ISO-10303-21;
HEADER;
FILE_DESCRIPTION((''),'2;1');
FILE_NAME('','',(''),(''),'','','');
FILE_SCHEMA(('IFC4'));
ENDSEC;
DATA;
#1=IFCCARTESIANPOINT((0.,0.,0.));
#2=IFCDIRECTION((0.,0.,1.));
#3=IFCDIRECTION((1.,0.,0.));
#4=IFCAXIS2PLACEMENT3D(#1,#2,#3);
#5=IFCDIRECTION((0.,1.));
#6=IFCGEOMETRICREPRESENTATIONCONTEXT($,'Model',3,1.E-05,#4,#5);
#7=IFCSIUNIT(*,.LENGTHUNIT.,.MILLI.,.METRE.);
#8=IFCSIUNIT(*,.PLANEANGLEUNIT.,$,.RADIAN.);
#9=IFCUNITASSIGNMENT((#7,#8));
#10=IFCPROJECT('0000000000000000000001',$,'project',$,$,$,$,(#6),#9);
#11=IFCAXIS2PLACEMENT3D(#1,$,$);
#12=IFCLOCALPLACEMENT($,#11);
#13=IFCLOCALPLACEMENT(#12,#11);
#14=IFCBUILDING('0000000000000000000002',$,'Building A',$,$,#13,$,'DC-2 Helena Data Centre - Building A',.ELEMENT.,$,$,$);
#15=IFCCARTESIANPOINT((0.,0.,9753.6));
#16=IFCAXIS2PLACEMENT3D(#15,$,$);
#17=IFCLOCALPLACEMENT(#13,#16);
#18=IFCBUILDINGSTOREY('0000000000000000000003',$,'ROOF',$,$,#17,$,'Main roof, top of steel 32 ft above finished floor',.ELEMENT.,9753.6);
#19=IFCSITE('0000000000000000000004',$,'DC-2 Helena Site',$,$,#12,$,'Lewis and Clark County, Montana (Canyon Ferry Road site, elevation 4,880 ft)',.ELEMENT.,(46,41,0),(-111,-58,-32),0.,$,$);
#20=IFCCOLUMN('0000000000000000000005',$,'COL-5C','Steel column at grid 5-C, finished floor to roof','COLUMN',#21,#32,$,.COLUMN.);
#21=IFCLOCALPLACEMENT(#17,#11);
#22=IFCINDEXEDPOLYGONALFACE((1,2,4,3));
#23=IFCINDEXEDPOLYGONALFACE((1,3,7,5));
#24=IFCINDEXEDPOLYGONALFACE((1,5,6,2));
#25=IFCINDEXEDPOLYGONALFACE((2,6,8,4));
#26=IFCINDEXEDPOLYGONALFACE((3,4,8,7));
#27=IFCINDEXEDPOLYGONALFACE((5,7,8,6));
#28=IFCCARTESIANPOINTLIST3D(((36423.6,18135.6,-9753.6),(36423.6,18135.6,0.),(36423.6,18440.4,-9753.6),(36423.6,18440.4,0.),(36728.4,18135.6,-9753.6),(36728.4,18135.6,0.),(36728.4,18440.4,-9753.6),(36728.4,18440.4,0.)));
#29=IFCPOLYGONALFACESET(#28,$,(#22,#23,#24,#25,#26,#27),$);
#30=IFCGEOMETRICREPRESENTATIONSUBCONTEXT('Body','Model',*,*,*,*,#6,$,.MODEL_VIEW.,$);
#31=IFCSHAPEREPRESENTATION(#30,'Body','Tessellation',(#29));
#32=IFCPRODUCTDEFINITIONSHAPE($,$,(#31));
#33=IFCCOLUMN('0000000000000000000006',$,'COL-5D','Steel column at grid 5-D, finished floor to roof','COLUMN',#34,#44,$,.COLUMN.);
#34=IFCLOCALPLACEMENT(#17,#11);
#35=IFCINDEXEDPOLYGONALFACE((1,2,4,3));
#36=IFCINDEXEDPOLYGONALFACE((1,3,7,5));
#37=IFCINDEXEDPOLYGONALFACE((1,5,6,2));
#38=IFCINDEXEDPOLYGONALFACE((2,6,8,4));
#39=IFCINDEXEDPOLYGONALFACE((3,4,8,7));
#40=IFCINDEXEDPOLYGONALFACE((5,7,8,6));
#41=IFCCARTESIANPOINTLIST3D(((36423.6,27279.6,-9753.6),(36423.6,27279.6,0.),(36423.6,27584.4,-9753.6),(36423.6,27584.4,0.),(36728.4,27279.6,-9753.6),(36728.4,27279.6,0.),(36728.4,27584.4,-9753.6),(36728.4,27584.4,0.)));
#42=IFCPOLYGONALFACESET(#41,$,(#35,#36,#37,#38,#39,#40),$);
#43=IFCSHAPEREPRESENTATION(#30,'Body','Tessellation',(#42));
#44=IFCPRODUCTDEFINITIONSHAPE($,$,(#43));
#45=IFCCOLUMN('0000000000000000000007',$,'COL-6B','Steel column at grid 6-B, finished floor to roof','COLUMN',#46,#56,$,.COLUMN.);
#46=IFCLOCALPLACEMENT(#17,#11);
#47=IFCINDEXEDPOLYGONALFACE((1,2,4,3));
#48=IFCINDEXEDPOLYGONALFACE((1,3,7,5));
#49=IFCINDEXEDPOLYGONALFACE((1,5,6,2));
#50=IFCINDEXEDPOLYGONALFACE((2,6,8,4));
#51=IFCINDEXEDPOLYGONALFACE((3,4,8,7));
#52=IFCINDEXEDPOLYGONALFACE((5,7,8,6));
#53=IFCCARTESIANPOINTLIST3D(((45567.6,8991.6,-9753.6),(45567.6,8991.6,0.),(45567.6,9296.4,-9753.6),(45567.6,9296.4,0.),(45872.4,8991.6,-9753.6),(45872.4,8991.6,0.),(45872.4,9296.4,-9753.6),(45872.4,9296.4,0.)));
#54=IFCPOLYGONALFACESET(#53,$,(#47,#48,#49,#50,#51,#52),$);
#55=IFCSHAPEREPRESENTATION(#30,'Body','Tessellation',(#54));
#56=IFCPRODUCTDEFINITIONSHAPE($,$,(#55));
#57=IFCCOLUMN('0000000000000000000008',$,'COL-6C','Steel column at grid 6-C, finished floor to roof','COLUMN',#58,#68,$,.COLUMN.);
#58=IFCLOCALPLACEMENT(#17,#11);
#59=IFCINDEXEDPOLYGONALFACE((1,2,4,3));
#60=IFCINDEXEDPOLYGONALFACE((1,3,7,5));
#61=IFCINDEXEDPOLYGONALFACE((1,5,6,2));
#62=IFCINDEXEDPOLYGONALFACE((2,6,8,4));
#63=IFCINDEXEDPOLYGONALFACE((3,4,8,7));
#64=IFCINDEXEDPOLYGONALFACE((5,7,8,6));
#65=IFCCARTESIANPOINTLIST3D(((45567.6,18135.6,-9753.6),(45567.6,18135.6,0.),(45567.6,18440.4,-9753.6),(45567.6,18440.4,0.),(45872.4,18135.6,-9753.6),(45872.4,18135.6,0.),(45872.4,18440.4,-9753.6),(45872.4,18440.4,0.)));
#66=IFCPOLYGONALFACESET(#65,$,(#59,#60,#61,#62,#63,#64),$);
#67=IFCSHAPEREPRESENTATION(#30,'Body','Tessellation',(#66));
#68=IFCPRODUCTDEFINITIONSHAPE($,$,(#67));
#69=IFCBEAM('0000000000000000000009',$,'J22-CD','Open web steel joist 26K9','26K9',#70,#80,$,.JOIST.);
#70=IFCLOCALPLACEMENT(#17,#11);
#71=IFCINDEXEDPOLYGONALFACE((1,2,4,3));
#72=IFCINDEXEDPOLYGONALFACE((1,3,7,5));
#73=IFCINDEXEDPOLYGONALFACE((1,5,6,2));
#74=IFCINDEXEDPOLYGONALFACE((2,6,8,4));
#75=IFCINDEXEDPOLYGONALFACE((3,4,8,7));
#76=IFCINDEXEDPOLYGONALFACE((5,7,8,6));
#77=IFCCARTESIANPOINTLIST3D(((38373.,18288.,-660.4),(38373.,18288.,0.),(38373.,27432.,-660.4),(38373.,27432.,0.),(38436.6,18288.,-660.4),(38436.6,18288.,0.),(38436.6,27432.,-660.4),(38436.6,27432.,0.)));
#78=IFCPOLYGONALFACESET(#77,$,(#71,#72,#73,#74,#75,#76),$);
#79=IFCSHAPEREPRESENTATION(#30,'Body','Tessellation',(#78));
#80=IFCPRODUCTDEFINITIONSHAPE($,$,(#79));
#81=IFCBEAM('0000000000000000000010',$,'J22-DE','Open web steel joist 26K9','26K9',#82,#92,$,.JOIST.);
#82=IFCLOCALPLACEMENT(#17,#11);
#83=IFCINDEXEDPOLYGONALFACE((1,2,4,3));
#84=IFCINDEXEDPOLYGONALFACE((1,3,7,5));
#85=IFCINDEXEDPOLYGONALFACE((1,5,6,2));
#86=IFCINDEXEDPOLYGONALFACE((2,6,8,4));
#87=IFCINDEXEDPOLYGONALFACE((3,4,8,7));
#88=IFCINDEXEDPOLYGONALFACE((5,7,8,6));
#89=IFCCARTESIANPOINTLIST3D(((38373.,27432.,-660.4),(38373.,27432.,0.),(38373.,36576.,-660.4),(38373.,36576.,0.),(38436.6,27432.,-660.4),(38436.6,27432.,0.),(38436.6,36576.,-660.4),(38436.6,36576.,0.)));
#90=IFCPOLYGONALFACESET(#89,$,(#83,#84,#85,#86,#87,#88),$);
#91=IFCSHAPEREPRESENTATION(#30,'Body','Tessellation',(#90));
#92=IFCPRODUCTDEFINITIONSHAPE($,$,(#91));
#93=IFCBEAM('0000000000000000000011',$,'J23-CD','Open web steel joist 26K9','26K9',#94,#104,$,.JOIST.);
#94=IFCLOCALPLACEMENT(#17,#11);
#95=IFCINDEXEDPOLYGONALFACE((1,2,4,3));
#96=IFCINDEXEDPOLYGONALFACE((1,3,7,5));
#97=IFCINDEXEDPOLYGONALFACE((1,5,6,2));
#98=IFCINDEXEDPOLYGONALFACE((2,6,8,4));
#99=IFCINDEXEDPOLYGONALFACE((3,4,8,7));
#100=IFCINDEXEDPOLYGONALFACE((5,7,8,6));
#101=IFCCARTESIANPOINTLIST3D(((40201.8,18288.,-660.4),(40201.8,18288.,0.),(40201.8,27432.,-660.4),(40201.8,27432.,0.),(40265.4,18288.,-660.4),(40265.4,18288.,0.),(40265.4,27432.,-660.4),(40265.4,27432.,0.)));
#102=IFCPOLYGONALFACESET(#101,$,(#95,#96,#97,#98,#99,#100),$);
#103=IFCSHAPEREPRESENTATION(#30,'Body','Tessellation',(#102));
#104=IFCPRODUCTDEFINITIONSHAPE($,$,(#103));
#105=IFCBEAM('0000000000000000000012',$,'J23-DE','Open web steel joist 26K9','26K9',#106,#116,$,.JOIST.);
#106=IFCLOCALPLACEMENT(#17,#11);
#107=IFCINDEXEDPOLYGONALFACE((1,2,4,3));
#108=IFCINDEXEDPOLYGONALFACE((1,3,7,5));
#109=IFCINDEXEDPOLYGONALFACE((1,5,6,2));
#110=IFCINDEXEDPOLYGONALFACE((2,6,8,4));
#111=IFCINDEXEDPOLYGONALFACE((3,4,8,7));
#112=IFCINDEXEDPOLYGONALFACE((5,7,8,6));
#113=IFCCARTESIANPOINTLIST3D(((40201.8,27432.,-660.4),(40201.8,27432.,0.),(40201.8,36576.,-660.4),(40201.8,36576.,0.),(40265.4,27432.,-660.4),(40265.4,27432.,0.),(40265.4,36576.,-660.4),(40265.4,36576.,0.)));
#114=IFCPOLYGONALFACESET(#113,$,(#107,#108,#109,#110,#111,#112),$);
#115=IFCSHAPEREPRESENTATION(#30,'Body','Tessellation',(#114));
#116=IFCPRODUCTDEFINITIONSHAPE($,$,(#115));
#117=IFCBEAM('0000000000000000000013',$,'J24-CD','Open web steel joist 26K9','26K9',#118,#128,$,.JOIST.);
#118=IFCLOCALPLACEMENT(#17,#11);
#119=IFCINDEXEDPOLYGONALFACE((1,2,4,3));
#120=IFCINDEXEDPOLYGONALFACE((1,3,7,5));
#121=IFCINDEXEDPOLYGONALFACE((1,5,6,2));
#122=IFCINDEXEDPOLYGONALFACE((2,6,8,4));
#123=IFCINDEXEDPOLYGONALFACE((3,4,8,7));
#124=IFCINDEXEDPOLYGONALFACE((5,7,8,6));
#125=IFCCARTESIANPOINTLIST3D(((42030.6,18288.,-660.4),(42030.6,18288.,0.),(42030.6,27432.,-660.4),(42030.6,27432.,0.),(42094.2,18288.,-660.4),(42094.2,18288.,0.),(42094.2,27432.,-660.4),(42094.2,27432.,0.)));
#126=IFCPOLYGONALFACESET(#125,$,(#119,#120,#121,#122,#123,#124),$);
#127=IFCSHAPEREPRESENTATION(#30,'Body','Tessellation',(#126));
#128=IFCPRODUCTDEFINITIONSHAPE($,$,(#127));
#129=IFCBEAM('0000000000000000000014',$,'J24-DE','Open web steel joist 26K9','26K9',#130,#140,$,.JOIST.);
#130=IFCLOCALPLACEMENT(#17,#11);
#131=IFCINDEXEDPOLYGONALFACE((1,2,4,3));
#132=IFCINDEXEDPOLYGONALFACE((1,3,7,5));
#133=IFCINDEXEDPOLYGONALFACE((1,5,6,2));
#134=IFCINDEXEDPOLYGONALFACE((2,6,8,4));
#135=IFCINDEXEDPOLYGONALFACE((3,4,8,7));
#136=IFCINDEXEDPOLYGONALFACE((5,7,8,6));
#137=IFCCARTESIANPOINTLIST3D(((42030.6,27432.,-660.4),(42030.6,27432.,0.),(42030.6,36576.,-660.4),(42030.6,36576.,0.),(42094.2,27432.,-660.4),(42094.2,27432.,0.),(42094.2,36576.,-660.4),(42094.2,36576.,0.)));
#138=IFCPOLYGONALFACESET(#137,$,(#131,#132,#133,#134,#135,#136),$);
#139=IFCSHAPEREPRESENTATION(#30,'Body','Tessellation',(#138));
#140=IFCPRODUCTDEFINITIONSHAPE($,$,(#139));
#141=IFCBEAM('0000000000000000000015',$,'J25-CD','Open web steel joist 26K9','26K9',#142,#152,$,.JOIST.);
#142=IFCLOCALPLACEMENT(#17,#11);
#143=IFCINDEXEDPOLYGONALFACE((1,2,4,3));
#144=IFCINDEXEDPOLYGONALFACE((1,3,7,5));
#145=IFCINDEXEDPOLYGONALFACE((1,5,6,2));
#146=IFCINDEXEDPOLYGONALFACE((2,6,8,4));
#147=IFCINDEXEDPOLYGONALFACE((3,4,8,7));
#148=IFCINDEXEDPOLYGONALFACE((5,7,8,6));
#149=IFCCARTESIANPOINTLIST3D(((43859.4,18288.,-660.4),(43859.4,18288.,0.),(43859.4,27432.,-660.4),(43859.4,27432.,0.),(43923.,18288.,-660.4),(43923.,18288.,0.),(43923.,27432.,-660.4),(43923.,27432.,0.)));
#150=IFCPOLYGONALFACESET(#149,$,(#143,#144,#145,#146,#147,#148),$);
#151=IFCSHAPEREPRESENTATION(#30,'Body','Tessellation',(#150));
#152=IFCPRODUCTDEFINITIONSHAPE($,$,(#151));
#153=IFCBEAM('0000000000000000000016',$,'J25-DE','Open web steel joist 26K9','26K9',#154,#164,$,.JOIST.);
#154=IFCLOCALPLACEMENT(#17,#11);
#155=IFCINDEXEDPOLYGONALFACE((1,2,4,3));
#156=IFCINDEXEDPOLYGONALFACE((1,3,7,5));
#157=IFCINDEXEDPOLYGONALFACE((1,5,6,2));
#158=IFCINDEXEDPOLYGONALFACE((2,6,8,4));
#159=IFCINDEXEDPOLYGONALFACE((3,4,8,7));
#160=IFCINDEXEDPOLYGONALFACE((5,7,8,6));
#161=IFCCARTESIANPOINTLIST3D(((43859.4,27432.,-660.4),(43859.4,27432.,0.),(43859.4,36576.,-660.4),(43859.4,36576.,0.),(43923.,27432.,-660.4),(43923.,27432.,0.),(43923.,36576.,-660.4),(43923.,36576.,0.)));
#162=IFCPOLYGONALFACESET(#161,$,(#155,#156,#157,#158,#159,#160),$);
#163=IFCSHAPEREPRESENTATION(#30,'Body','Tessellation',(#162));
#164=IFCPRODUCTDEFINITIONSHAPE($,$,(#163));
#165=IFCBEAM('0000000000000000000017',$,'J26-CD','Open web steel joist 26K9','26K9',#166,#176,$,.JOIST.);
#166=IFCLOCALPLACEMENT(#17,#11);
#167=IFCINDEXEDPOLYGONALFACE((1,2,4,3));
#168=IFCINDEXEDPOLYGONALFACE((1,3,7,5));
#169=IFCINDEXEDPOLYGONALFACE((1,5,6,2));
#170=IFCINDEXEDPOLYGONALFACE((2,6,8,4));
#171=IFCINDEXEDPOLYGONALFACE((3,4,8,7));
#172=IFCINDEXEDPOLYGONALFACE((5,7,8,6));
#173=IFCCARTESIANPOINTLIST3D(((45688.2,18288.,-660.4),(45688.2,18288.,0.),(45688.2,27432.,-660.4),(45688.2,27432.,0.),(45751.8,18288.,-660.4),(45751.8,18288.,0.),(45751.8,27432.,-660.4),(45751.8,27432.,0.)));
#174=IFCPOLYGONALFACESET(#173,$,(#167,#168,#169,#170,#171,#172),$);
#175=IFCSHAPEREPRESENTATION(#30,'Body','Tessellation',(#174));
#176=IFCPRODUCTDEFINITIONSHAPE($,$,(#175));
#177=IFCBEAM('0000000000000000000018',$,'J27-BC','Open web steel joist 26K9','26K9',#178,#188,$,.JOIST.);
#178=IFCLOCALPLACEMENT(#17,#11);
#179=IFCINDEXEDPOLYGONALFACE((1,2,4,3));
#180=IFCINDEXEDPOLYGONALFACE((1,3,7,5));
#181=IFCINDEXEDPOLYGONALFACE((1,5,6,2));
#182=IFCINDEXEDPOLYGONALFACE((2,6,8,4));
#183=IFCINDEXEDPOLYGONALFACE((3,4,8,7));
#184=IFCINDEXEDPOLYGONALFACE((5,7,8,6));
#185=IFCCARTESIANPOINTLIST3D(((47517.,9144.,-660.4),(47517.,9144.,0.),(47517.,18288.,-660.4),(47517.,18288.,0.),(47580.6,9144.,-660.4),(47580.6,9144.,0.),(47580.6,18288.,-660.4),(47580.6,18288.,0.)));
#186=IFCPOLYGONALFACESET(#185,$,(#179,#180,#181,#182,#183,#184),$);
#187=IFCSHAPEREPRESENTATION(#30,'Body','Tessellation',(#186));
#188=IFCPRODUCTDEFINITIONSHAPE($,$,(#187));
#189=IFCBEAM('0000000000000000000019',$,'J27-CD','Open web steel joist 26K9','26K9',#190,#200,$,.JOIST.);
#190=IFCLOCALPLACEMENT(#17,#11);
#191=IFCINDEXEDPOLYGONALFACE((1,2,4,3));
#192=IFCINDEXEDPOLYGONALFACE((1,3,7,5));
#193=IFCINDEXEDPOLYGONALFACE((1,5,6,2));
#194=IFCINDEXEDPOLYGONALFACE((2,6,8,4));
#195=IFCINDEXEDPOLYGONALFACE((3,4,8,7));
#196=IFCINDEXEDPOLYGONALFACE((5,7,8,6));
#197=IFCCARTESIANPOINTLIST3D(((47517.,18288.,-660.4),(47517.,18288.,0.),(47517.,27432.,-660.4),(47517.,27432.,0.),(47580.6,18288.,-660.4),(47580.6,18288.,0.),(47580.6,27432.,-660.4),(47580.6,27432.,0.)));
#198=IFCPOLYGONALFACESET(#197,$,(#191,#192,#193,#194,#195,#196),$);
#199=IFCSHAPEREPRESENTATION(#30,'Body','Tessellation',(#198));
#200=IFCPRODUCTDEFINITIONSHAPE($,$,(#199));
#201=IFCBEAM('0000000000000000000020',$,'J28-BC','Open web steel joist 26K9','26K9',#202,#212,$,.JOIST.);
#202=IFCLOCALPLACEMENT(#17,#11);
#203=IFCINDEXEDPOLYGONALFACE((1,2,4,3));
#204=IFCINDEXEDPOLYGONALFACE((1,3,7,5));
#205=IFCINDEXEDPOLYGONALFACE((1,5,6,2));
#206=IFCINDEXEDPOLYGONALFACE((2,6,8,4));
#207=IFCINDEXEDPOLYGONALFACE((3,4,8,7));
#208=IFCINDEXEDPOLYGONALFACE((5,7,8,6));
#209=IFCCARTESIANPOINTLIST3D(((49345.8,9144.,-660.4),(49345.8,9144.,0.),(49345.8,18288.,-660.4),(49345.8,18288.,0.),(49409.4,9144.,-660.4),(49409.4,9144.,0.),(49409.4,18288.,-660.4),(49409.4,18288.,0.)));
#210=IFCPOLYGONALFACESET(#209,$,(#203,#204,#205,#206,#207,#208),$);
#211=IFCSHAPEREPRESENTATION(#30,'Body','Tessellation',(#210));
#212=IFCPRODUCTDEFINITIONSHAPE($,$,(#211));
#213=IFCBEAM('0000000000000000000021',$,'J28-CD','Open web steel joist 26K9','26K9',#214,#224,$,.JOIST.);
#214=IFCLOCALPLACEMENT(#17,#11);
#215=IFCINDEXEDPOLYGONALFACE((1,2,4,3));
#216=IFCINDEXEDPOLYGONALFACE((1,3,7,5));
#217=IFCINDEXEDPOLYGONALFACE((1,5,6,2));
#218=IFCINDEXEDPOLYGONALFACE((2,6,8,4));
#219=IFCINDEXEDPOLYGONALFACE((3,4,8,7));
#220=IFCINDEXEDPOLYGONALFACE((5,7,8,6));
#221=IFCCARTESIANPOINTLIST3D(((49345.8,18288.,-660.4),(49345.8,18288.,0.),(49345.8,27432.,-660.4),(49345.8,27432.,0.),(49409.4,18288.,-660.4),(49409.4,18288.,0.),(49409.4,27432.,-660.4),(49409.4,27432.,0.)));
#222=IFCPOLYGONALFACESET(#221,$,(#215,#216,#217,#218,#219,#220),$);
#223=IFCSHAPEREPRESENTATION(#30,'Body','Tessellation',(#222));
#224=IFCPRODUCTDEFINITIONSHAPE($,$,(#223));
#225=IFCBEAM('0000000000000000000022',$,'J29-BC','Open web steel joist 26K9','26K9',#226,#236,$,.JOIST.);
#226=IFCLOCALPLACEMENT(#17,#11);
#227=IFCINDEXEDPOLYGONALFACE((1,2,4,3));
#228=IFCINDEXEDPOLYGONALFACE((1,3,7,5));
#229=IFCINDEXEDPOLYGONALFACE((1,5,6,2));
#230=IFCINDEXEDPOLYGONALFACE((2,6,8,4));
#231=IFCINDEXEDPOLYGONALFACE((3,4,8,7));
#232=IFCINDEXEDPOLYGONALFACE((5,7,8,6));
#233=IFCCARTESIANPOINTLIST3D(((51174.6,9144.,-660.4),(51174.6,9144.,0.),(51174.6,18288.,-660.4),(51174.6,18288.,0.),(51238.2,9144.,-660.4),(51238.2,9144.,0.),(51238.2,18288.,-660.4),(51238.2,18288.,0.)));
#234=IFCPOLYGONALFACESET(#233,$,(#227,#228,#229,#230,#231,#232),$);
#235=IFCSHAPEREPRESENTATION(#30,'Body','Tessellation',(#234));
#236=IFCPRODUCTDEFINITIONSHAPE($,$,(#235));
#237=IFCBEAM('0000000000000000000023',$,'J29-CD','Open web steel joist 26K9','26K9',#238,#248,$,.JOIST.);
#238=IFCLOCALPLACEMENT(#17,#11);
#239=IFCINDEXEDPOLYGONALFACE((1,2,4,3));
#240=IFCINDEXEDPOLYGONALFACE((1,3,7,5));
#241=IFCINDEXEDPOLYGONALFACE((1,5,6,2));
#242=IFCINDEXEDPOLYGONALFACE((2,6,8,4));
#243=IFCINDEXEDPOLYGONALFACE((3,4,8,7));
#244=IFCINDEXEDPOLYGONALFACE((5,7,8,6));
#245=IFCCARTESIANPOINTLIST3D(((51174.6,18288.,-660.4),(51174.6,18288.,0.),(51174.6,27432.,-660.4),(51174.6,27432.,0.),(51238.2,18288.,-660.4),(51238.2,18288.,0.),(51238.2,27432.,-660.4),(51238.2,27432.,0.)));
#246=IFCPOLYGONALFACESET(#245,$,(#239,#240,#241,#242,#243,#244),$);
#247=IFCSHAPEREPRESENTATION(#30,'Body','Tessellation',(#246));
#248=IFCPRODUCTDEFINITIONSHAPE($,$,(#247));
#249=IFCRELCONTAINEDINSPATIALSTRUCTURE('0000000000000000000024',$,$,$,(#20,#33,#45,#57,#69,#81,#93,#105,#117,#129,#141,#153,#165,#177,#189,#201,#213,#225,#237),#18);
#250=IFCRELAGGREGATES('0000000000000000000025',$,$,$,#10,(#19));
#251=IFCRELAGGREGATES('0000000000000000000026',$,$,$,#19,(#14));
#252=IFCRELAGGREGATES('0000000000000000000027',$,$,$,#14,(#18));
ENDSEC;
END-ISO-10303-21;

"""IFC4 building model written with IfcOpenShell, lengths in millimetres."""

from ifc_helpers import new_model, si_unit, direction, frame, origin, origin_with_axes, origin_2d, place, context, subcontext, project, spatial, rectangle, extrude, element, save


model = new_model("IFC4")

# Units and contexts
model_context = context("Model", 3, precision=1e-05, world=origin_with_axes(), true_north=direction((0.0, 1.0)))
body_context = subcontext(model_context, "Body", "Model", "MODEL_VIEW")
ifc_project = project(units=[si_unit("LENGTHUNIT", "METRE", prefix="MILLI"), si_unit("PLANEANGLEUNIT", "RADIAN")], contexts=[model_context])

# Site, building, storey
site_placement = place(None, origin())
site = spatial("IfcSite", under=ifc_project, at=site_placement, Name="DC-2 Helena Site", LongName="Lewis and Clark County, Montana (Canyon Ferry Road site, elevation 4,880 ft)", CompositionType="ELEMENT", RefLatitude=(46, 41, 0), RefLongitude=(-111, -58, -32), RefElevation=0.0)
building_placement = place(site_placement, origin())
building = spatial("IfcBuilding", under=site, at=building_placement, Name="Building A", LongName="DC-2 Helena Data Centre - Building A", CompositionType="ELEMENT")
storey_placement = place(building_placement, frame((0.0, 0.0, 9753.6)))
storey = spatial("IfcBuildingStorey", under=building, at=storey_placement, Name="ROOF", LongName="Main roof, top of steel 32 ft above finished floor", CompositionType="ELEMENT", Elevation=9753.6)

# Columns
for number, where, name, description in (
    (1, (36576.0, 18288.0, -9753.6), "COL-5C", "Steel column at grid 5-C, finished floor to roof"),
    (2, (36576.0, 27432.0, -9753.6), "COL-5D", "Steel column at grid 5-D, finished floor to roof"),
    (3, (45720.0, 9144.0, -9753.6), "COL-6B", "Steel column at grid 6-B, finished floor to roof"),
    (4, (45720.0, 18288.0, -9753.6), "COL-6C", "Steel column at grid 6-C, finished floor to roof"),
):
    element("IfcColumn", number, at=place(storey_placement, frame(where)), inside=storey, Name=name, Description=description, ObjectType="COLUMN", PredefinedType="COLUMN", context=body_context, shape_type="SweptSolid", body=[
        extrude(rectangle(XDim=304.8, YDim=304.8, at=origin_2d()), origin(), (0.0, 0.0, 1.0), 9753.6),
    ])

# Beams
for number, where, name in (
    (5, (38404.8, 18288.0, 0.0), "J22-CD"),
    (6, (38404.8, 27432.0, 0.0), "J22-DE"),
    (7, (40233.6, 18288.0, 0.0), "J23-CD"),
    (8, (40233.6, 27432.0, 0.0), "J23-DE"),
    (9, (42062.4, 18288.0, 0.0), "J24-CD"),
    (10, (42062.4, 27432.0, 0.0), "J24-DE"),
    (11, (43891.2, 18288.0, 0.0), "J25-CD"),
    (12, (43891.2, 27432.0, 0.0), "J25-DE"),
):
    element("IfcBeam", number, at=place(storey_placement, frame(where)), inside=storey, Name=name, Description="Open web steel joist 26K9", ObjectType="26K9", PredefinedType="JOIST", context=body_context, shape_type="SweptSolid", body=[
        extrude(rectangle(XDim=63.5, YDim=660.4, at=origin_2d()), frame((0.0, 0.0, -330.2), z_axis=(0.0, 1.0, 0.0), x_axis=(1.0, 0.0, 0.0)), (0.0, 0.0, 1.0), 9144.0),
    ])
placement = place(storey_placement, frame((45720.0, 18288.0, 0.0)))
element("IfcBeam", 13, at=placement, inside=storey, Name="J26-CD", Description="Open web steel joist 26K9", ObjectType="26K9", PredefinedType="JOIST", context=body_context, shape_type="SweptSolid", body=[
    extrude(rectangle(XDim=63.5, YDim=660.4, at=origin_2d()), frame((0.0, 0.0, -330.2), z_axis=(0.0, 1.0, 0.0), x_axis=(1.0, 0.0, 0.0)), (0.0, 0.0, 1.0), 9144.0),
])
for number, where, name in (
    (14, (47548.8, 9144.0, 0.0), "J27-BC"),
    (15, (47548.8, 18288.0, 0.0), "J27-CD"),
    (16, (49377.6, 9144.0, 0.0), "J28-BC"),
    (17, (49377.6, 18288.0, 0.0), "J28-CD"),
    (18, (51206.4, 9144.0, 0.0), "J29-BC"),
    (19, (51206.4, 18288.0, 0.0), "J29-CD"),
):
    element("IfcBeam", number, at=place(storey_placement, frame(where)), inside=storey, Name=name, Description="Open web steel joist 26K9", ObjectType="26K9", PredefinedType="JOIST", context=body_context, shape_type="SweptSolid", body=[
        extrude(rectangle(XDim=63.5, YDim=660.4, at=origin_2d()), frame((0.0, 0.0, -330.2), z_axis=(0.0, 1.0, 0.0), x_axis=(1.0, 0.0, 0.0)), (0.0, 0.0, 1.0), 9144.0),
    ])

save(model, "model.ifc")
